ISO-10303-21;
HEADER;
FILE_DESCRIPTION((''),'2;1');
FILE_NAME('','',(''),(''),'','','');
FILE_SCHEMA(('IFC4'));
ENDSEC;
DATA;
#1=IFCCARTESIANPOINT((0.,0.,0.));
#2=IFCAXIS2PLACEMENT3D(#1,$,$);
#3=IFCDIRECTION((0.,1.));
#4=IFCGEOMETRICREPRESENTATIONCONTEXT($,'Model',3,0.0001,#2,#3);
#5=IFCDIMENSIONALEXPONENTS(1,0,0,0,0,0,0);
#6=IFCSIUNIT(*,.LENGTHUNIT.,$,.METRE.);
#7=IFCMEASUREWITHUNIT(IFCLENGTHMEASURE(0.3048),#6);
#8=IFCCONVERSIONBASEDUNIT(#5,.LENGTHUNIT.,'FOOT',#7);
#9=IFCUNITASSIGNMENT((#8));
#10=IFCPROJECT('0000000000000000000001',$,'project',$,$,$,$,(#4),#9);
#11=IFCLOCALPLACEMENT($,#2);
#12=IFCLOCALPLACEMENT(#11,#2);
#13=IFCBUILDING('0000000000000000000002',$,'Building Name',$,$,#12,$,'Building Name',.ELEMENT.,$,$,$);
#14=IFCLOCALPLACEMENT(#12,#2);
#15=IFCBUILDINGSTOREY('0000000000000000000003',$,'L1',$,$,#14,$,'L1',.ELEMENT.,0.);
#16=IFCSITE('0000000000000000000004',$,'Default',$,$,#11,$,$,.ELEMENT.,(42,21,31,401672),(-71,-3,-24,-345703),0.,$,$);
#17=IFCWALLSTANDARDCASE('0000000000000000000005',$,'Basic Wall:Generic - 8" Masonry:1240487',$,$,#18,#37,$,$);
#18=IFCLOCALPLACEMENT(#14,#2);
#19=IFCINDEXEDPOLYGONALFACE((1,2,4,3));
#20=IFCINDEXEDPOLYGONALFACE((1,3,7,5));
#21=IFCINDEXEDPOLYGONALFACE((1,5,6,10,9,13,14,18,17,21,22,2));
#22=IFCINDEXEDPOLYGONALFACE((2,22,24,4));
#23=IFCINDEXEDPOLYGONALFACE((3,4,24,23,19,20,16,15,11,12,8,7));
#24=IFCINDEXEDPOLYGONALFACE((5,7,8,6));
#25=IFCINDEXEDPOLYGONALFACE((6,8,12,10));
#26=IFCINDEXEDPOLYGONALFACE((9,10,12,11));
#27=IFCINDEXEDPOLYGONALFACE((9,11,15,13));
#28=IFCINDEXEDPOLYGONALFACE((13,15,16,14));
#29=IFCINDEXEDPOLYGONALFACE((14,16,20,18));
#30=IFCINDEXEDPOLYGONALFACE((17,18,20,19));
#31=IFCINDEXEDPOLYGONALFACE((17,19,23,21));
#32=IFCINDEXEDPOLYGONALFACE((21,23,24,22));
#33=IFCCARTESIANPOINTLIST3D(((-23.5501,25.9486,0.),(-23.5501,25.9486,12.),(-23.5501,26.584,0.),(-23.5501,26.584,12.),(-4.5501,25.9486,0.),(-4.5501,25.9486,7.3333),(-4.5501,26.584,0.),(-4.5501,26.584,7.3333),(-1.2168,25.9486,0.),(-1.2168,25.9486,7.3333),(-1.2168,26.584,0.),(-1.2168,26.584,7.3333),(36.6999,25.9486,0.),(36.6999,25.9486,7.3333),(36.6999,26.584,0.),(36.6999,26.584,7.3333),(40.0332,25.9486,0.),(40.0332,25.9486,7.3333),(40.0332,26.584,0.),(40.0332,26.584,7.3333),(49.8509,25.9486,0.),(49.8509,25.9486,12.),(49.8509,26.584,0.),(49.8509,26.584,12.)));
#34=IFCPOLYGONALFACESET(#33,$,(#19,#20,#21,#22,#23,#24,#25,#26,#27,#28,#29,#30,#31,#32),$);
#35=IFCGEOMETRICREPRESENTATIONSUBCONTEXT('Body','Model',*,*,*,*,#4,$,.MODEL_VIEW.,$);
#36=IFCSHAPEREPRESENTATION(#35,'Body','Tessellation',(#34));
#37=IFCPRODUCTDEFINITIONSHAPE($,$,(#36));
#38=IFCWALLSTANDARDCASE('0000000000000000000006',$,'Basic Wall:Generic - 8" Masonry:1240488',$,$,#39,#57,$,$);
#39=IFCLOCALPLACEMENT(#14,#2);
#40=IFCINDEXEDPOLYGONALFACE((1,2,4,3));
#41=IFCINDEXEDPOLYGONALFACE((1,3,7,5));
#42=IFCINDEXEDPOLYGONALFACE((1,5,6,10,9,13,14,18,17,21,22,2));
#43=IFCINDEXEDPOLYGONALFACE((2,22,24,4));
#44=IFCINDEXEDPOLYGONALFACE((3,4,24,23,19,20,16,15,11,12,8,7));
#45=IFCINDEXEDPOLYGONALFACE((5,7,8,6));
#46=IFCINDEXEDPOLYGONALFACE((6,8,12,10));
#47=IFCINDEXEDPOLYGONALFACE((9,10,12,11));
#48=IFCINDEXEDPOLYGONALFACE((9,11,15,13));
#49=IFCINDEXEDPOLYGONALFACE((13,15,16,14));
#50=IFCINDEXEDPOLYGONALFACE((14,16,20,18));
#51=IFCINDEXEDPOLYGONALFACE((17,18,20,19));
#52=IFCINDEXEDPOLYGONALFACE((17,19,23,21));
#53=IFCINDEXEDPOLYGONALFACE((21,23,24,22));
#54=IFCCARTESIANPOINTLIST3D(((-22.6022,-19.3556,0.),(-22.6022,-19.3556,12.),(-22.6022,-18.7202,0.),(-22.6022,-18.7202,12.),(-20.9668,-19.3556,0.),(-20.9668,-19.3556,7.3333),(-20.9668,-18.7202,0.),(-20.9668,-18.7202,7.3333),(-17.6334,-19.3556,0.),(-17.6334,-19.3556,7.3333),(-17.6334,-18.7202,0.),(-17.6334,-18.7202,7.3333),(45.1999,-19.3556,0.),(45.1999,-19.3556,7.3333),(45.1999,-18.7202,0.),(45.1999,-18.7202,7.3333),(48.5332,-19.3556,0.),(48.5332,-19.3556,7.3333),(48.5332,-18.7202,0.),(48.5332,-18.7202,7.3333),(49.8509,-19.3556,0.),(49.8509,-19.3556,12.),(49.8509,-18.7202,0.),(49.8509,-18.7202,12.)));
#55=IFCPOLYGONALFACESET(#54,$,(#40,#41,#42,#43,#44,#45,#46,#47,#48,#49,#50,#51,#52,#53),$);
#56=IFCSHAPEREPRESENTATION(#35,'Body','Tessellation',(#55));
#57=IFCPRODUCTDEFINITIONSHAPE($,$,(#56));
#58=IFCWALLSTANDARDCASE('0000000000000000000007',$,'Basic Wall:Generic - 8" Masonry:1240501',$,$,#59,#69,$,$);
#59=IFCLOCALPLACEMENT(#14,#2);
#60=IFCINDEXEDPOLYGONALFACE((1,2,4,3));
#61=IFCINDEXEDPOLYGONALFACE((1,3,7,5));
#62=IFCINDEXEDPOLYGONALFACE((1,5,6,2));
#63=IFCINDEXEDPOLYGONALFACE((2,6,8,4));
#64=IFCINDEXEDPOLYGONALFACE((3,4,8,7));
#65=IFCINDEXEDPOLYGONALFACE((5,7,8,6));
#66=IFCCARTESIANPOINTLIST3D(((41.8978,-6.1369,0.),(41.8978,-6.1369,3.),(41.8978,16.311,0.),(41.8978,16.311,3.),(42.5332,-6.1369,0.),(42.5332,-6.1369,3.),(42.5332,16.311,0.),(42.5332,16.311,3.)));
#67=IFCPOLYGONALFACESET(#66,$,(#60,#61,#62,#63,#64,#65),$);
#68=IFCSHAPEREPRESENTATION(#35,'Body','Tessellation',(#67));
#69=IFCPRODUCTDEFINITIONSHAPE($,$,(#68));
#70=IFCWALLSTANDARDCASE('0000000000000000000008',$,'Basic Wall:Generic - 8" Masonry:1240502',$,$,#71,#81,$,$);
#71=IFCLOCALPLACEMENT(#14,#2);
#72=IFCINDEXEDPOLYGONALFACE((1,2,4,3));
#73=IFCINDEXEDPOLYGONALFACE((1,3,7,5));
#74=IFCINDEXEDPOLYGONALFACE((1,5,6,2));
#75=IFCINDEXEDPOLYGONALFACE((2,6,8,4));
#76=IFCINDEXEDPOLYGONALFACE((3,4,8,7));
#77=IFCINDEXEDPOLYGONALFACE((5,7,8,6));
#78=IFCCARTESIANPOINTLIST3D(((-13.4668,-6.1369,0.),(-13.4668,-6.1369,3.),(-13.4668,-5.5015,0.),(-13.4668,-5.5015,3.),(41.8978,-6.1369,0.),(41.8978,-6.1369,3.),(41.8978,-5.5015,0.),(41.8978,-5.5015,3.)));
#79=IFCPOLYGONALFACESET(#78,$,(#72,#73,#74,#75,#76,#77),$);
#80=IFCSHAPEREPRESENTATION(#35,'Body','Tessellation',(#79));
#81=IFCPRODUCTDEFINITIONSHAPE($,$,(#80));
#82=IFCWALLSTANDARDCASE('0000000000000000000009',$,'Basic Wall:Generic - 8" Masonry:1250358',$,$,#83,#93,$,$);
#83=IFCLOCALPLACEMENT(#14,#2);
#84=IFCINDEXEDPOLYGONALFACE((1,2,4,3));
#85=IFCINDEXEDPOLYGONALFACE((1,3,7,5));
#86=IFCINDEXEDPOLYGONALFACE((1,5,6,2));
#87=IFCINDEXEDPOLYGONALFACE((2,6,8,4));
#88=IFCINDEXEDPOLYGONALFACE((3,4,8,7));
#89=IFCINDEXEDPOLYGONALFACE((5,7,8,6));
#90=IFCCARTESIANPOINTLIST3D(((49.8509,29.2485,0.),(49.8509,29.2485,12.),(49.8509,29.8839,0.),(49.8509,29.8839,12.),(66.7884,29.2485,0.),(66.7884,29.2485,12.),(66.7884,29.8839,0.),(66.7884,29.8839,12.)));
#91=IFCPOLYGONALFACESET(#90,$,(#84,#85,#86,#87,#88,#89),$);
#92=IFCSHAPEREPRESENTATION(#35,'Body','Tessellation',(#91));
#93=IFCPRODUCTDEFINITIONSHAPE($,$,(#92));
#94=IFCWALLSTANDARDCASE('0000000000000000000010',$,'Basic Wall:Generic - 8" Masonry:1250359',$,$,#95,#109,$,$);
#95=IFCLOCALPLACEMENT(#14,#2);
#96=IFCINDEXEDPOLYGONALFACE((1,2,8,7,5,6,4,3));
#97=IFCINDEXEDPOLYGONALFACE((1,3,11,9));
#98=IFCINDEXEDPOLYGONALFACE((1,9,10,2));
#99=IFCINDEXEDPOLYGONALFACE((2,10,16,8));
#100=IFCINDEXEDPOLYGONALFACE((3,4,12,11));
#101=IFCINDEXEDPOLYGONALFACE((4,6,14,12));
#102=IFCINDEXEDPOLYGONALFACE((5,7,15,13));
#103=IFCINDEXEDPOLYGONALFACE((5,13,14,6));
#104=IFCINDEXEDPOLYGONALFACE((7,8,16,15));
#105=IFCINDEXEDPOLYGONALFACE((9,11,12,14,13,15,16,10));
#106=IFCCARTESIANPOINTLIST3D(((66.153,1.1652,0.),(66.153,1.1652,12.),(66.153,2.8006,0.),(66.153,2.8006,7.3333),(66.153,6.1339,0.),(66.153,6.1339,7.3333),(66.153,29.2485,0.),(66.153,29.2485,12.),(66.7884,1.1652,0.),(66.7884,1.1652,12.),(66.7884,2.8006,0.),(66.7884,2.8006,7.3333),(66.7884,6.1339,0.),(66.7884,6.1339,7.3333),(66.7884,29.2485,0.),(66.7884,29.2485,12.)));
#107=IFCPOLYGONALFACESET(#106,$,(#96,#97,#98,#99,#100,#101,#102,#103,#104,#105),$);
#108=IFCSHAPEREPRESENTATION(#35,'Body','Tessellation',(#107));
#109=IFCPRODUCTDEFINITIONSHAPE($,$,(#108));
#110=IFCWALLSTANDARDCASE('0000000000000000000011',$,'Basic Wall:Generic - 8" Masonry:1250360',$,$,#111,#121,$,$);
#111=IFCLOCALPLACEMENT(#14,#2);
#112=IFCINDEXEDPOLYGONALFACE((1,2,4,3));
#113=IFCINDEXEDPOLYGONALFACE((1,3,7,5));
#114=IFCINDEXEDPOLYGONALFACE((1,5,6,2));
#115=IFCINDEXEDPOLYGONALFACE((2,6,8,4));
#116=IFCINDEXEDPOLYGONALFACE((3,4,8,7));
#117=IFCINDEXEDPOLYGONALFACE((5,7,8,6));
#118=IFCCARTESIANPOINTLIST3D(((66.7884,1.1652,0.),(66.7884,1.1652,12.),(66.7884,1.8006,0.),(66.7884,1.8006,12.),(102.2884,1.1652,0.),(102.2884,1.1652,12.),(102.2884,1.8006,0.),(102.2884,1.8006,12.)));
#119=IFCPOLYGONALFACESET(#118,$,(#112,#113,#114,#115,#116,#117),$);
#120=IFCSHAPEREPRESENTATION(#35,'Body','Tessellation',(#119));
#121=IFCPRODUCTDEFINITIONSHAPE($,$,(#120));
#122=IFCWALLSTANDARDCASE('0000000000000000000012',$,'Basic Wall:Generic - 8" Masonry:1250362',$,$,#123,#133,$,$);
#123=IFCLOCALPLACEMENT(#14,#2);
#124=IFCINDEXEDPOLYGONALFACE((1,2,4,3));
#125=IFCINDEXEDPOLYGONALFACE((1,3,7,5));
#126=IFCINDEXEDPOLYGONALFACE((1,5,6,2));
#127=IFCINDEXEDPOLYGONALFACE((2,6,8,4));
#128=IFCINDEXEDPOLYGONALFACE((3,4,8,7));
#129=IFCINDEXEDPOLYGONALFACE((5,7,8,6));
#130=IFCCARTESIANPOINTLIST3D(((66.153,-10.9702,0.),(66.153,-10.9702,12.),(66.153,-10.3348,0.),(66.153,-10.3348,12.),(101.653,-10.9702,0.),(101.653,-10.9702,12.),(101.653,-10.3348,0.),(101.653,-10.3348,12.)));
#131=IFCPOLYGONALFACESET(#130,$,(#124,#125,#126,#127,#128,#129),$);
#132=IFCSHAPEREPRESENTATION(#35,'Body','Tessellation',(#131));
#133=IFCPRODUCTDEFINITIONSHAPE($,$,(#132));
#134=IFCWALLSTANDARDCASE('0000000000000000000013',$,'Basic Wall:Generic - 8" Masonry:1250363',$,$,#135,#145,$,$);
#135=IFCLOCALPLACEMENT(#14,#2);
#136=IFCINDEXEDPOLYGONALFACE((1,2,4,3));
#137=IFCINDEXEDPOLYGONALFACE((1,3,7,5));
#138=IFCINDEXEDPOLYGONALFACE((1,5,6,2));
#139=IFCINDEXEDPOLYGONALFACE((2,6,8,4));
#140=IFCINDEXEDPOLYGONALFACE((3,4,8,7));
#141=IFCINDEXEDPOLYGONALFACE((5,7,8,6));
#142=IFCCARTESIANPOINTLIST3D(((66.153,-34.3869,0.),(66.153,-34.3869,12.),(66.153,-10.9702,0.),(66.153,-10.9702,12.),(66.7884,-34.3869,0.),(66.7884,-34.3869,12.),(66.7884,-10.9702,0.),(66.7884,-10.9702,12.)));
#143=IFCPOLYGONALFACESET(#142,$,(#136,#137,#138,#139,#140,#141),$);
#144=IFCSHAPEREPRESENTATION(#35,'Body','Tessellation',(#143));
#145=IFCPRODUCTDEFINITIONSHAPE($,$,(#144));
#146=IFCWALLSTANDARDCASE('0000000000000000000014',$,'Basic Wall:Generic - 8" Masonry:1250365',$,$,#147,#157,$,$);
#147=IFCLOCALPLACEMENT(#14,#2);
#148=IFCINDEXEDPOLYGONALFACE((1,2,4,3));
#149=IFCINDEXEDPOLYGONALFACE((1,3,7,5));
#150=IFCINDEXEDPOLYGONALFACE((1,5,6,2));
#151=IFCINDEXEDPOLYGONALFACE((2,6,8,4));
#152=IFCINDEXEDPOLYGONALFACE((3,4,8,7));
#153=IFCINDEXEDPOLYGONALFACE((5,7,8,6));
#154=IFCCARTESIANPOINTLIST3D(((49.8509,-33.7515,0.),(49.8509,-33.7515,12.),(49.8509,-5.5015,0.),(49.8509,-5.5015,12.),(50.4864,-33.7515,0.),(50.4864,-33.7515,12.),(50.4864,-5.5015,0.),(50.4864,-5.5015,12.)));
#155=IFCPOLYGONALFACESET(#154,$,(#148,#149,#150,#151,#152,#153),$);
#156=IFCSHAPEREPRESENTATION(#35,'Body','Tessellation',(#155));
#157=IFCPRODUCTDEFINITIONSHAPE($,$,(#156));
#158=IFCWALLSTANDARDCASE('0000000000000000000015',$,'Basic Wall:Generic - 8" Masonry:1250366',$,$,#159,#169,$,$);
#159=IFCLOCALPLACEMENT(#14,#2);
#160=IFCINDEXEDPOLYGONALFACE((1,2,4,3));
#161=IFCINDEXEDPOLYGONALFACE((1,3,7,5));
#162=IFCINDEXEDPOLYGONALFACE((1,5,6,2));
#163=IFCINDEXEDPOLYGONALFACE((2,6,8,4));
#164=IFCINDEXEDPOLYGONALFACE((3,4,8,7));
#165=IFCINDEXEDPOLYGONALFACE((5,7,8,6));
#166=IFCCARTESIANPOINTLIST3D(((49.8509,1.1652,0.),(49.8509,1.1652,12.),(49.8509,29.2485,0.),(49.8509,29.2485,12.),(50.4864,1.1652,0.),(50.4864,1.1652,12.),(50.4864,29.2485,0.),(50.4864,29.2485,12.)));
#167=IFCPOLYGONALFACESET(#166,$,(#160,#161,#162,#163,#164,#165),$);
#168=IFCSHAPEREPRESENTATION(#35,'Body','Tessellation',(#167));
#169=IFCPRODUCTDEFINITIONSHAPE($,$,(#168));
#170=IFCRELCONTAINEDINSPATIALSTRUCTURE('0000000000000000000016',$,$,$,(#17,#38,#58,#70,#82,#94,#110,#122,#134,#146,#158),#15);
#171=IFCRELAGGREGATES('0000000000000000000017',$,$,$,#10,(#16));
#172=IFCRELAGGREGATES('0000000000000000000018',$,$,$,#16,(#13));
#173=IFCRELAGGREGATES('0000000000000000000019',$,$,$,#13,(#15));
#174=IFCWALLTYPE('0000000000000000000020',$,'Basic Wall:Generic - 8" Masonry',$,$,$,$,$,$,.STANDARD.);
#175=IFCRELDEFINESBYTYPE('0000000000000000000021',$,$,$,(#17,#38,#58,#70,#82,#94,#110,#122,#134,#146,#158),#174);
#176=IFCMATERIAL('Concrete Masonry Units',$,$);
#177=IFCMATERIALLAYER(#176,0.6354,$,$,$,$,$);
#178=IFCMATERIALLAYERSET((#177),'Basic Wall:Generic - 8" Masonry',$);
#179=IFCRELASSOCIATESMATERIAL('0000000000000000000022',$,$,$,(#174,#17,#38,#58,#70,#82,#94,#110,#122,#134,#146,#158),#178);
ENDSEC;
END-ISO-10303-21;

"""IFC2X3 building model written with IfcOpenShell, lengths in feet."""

from ifc_helpers import new_model, entity, si_unit, converted_unit, direction, frame, frame_2d, origin, place, context, subcontext, project, spatial, rectangle, extrude, material, layer, layer_set, layer_usage, type_object, element, save


model = new_model("IFC2X3")

# Units and contexts
model_context = context("Model", 3, precision=0.0001, world=origin(), true_north=direction((0.0, 1.0)))
body_context = subcontext(model_context, "Body", "Model", "MODEL_VIEW")
ifc_project = project(units=[converted_unit("LENGTHUNIT", "FOOT", entity("IfcLengthMeasure", 0.3048), si_unit("LENGTHUNIT", "METRE"), dimensions=[1, 0, 0, 0, 0, 0, 0])], contexts=[model_context])

# Site, building, storey
site_placement = place(None, origin())
site = spatial("IfcSite", under=ifc_project, at=site_placement, Name="Default", CompositionType="ELEMENT", RefLatitude=(42, 21, 31, 401672), RefLongitude=(-71, -3, -24, -345703), RefElevation=0.0)
building_placement = place(site_placement, origin())
building = spatial("IfcBuilding", under=site, at=building_placement, Name="Building Name", LongName="Building Name", CompositionType="ELEMENT")
storey_placement = place(building_placement, origin())
storey = spatial("IfcBuildingStorey", under=building, at=storey_placement, Name="L1", LongName="L1", CompositionType="ELEMENT", Elevation=0.0)

# Walls, openings
ifc_material_1 = material(Name="Concrete Masonry Units")
ifc_layer_1 = layer(ifc_material_1, 0.6354)
ifc_layer_set_1 = layer_set([ifc_layer_1], Name="Basic Wall:Generic - 8\" Masonry")
ifc_layer_usage_1 = layer_usage(ifc_layer_set_1, "AXIS2", "NEGATIVE", 0.3177)
wall_type_1 = type_object("IfcWallType", Name="Basic Wall:Generic - 8\" Masonry", PredefinedType="STANDARD", material=ifc_layer_set_1)
wall_1_placement = place(storey_placement, frame((49.8509, 26.2663, 0.0), z_axis=(0.0, 0.0, 1.0), x_axis=(-1.0, 0.0, 0.0)))
wall_1 = element("IfcWallStandardCase", 1, at=wall_1_placement, inside=storey, type_object=wall_type_1, material=ifc_layer_usage_1, Name="Basic Wall:Generic - 8\" Masonry:1240487", context=body_context, shape_type="SweptSolid", body=[
    extrude(rectangle(XDim=73.401, YDim=0.6354, at=frame_2d((36.7005, 0.0), x_axis=(1.0, 0.0))), origin(), (0.0, 0.0, 1.0), 12.0),
])
opening_1_placement = place(wall_1_placement, frame((13.151, 0.3177, 0.0)))
element("IfcOpeningElement", 2, at=opening_1_placement, cuts=wall_1, ObjectType="Opening", context=body_context, shape_type="SweptSolid", body=[
    extrude(rectangle(XDim=7.3333, YDim=3.3333, at=frame_2d((3.6667, 1.6667), x_axis=(1.0, 0.0))), frame((0.0, 0.0, 0.0), z_axis=(0.0, -1.0, 0.0), x_axis=(0.0, 0.0, 1.0)), (0.0, 0.0, 1.0), 0.6354),
])
opening_2_placement = place(wall_1_placement, frame((54.401, 0.3177, 0.0)))
element("IfcOpeningElement", 3, at=opening_2_placement, cuts=wall_1, ObjectType="Opening", context=body_context, shape_type="SweptSolid", body=[
    extrude(rectangle(XDim=7.3333, YDim=3.3333, at=frame_2d((3.6667, 1.6667), x_axis=(1.0, 0.0))), frame((0.0, 0.0, 0.0), z_axis=(0.0, -1.0, 0.0), x_axis=(0.0, 0.0, 1.0)), (0.0, 0.0, 1.0), 0.6354),
])
ifc_layer_usage_2 = layer_usage(ifc_layer_set_1, "AXIS2", "NEGATIVE", 0.3177)
wall_2_placement = place(storey_placement, frame((49.8509, -19.0379, 0.0), z_axis=(0.0, 0.0, 1.0), x_axis=(-1.0, 0.0, 0.0)))
wall_2 = element("IfcWallStandardCase", 4, at=wall_2_placement, inside=storey, type_object=wall_type_1, material=ifc_layer_usage_2, Name="Basic Wall:Generic - 8\" Masonry:1240488", context=body_context, shape_type="SweptSolid", body=[
    extrude(rectangle(XDim=72.4531, YDim=0.6354, at=frame_2d((36.2266, 0.0), x_axis=(1.0, 0.0))), origin(), (0.0, 0.0, 1.0), 12.0),
])
opening_3_placement = place(wall_2_placement, frame((1.3177, -0.3177, 0.0)))
element("IfcOpeningElement", 5, at=opening_3_placement, cuts=wall_2, ObjectType="Opening", context=body_context, shape_type="SweptSolid", body=[
    extrude(rectangle(XDim=7.3333, YDim=3.3333, at=frame_2d((3.6667, 1.6667), x_axis=(1.0, 0.0))), frame((0.0, 0.0, 0.0), z_axis=(0.0, 1.0, 0.0), x_axis=(0.0, 0.0, 1.0)), (0.0, 0.0, 1.0), 0.6354),
])
opening_4_placement = place(wall_2_placement, frame((67.4844, -0.3177, 0.0)))
element("IfcOpeningElement", 6, at=opening_4_placement, cuts=wall_2, ObjectType="Opening", context=body_context, shape_type="SweptSolid", body=[
    extrude(rectangle(XDim=7.3333, YDim=3.3333, at=frame_2d((3.6667, 1.6667), x_axis=(1.0, 0.0))), frame((0.0, 0.0, 0.0), z_axis=(0.0, 1.0, 0.0), x_axis=(0.0, 0.0, 1.0)), (0.0, 0.0, 1.0), 0.6354),
])

# Walls
ifc_layer_usage_3 = layer_usage(ifc_layer_set_1, "AXIS2", "NEGATIVE", 0.3177)
wall_3_placement = place(storey_placement, frame((42.2155, 16.311, 0.0), z_axis=(0.0, 0.0, 1.0), x_axis=(0.0, -1.0, 0.0)))
element("IfcWallStandardCase", 7, at=wall_3_placement, inside=storey, type_object=wall_type_1, material=ifc_layer_usage_3, Name="Basic Wall:Generic - 8\" Masonry:1240501", context=body_context, shape_type="SweptSolid", body=[
    extrude(rectangle(XDim=22.4479, YDim=0.6354, at=frame_2d((11.224, 0.0), x_axis=(-1.0, 0.0))), origin(), (0.0, 0.0, 1.0), 3.0),
])
ifc_layer_usage_4 = layer_usage(ifc_layer_set_1, "AXIS2", "NEGATIVE", 0.3177)
wall_4_placement = place(storey_placement, frame((41.8978, -5.8192, 0.0), z_axis=(0.0, 0.0, 1.0), x_axis=(-1.0, 0.0, 0.0)))
element("IfcWallStandardCase", 8, at=wall_4_placement, inside=storey, type_object=wall_type_1, material=ifc_layer_usage_4, Name="Basic Wall:Generic - 8\" Masonry:1240502", context=body_context, shape_type="SweptSolid", body=[
    extrude(rectangle(XDim=55.3646, YDim=0.6354, at=frame_2d((27.6823, 0.0), x_axis=(-1.0, 0.0))), origin(), (0.0, 0.0, 1.0), 3.0),
])
ifc_layer_usage_5 = layer_usage(ifc_layer_set_1, "AXIS2", "NEGATIVE", 0.3177)
wall_5_placement = place(storey_placement, frame((49.8509, 29.5662, 0.0)))
element("IfcWallStandardCase", 9, at=wall_5_placement, inside=storey, type_object=wall_type_1, material=ifc_layer_usage_5, Name="Basic Wall:Generic - 8\" Masonry:1250358", context=body_context, shape_type="SweptSolid", body=[
    extrude(rectangle(XDim=16.9375, YDim=0.6354, at=frame_2d((8.4688, 0.0), x_axis=(-1.0, 0.0))), origin(), (0.0, 0.0, 1.0), 12.0),
])

# Wall, opening
ifc_layer_usage_6 = layer_usage(ifc_layer_set_1, "AXIS2", "NEGATIVE", 0.3177)
wall_6_placement = place(storey_placement, frame((66.4707, 29.2485, 0.0), z_axis=(0.0, 0.0, 1.0), x_axis=(0.0, -1.0, 0.0)))
wall_6 = element("IfcWallStandardCase", 10, at=wall_6_placement, inside=storey, type_object=wall_type_1, material=ifc_layer_usage_6, Name="Basic Wall:Generic - 8\" Masonry:1250359", context=body_context, shape_type="SweptSolid", body=[
    extrude(rectangle(XDim=28.0833, YDim=0.6354, at=frame_2d((14.0417, 0.0), x_axis=(1.0, 0.0))), origin(), (0.0, 0.0, 1.0), 12.0),
])
opening_5_placement = place(wall_6_placement, frame((23.1146, -0.3177, 0.0)))
element("IfcOpeningElement", 11, at=opening_5_placement, cuts=wall_6, ObjectType="Opening", context=body_context, shape_type="SweptSolid", body=[
    extrude(rectangle(XDim=7.3333, YDim=3.3333, at=frame_2d((3.6667, 1.6667), x_axis=(1.0, 0.0))), frame((0.0, 0.0, 0.0), z_axis=(0.0, 1.0, 0.0), x_axis=(0.0, 0.0, 1.0)), (0.0, 0.0, 1.0), 0.6354),
])

# Wall
ifc_layer_usage_7 = layer_usage(ifc_layer_set_1, "AXIS2", "NEGATIVE", 0.3177)
wall_7_placement = place(storey_placement, frame((66.7884, 1.4829, 0.0)))
element("IfcWallStandardCase", 12, at=wall_7_placement, inside=storey, type_object=wall_type_1, material=ifc_layer_usage_7, Name="Basic Wall:Generic - 8\" Masonry:1250360", context=body_context, shape_type="SweptSolid", body=[
    extrude(rectangle(XDim=35.5, YDim=0.6354, at=frame_2d((17.75, 0.0), x_axis=(-1.0, 0.0))), origin(), (0.0, 0.0, 1.0), 12.0),
])

# Walls
ifc_layer_usage_8 = layer_usage(ifc_layer_set_1, "AXIS2", "NEGATIVE", 0.3177)
wall_8_placement = place(storey_placement, frame((101.653, -10.6525, 0.0), z_axis=(0.0, 0.0, 1.0), x_axis=(-1.0, 0.0, 0.0)))
element("IfcWallStandardCase", 13, at=wall_8_placement, inside=storey, type_object=wall_type_1, material=ifc_layer_usage_8, Name="Basic Wall:Generic - 8\" Masonry:1250362", context=body_context, shape_type="SweptSolid", body=[
    extrude(rectangle(XDim=35.5, YDim=0.6354, at=frame_2d((17.75, 0.0), x_axis=(-1.0, 0.0))), origin(), (0.0, 0.0, 1.0), 12.0),
])
ifc_layer_usage_9 = layer_usage(ifc_layer_set_1, "AXIS2", "NEGATIVE", 0.3177)
wall_9_placement = place(storey_placement, frame((66.4707, -10.9702, 0.0), z_axis=(0.0, 0.0, 1.0), x_axis=(0.0, -1.0, 0.0)))
element("IfcWallStandardCase", 14, at=wall_9_placement, inside=storey, type_object=wall_type_1, material=ifc_layer_usage_9, Name="Basic Wall:Generic - 8\" Masonry:1250363", context=body_context, shape_type="SweptSolid", body=[
    extrude(rectangle(XDim=23.4167, YDim=0.6354, at=frame_2d((11.7083, 0.0), x_axis=(-1.0, 0.0))), origin(), (0.0, 0.0, 1.0), 12.0),
])

# Walls
ifc_layer_usage_10 = layer_usage(ifc_layer_set_1, "AXIS2", "NEGATIVE", 0.3177)
wall_10_placement = place(storey_placement, frame((50.1686, -33.7515, 0.0), z_axis=(0.0, 0.0, 1.0), x_axis=(0.0, 1.0, 0.0)))
element("IfcWallStandardCase", 15, at=wall_10_placement, inside=storey, type_object=wall_type_1, material=ifc_layer_usage_10, Name="Basic Wall:Generic - 8\" Masonry:1250365", context=body_context, shape_type="SweptSolid", body=[
    extrude(rectangle(XDim=28.25, YDim=0.6354, at=frame_2d((14.125, 0.0), x_axis=(-1.0, 0.0))), origin(), (0.0, 0.0, 1.0), 12.0),
])
ifc_layer_usage_11 = layer_usage(ifc_layer_set_1, "AXIS2", "NEGATIVE", 0.3177)
wall_11_placement = place(storey_placement, frame((50.1686, 29.2485, 0.0), z_axis=(0.0, 0.0, 1.0), x_axis=(0.0, -1.0, 0.0)))
element("IfcWallStandardCase", 16, at=wall_11_placement, inside=storey, type_object=wall_type_1, material=ifc_layer_usage_11, Name="Basic Wall:Generic - 8\" Masonry:1250366", context=body_context, shape_type="SweptSolid", body=[
    extrude(rectangle(XDim=28.0833, YDim=0.6354, at=frame_2d((14.0417, 0.0), x_axis=(-1.0, 0.0))), origin(), (0.0, 0.0, 1.0), 12.0),
])

save(model, "model.ifc")
